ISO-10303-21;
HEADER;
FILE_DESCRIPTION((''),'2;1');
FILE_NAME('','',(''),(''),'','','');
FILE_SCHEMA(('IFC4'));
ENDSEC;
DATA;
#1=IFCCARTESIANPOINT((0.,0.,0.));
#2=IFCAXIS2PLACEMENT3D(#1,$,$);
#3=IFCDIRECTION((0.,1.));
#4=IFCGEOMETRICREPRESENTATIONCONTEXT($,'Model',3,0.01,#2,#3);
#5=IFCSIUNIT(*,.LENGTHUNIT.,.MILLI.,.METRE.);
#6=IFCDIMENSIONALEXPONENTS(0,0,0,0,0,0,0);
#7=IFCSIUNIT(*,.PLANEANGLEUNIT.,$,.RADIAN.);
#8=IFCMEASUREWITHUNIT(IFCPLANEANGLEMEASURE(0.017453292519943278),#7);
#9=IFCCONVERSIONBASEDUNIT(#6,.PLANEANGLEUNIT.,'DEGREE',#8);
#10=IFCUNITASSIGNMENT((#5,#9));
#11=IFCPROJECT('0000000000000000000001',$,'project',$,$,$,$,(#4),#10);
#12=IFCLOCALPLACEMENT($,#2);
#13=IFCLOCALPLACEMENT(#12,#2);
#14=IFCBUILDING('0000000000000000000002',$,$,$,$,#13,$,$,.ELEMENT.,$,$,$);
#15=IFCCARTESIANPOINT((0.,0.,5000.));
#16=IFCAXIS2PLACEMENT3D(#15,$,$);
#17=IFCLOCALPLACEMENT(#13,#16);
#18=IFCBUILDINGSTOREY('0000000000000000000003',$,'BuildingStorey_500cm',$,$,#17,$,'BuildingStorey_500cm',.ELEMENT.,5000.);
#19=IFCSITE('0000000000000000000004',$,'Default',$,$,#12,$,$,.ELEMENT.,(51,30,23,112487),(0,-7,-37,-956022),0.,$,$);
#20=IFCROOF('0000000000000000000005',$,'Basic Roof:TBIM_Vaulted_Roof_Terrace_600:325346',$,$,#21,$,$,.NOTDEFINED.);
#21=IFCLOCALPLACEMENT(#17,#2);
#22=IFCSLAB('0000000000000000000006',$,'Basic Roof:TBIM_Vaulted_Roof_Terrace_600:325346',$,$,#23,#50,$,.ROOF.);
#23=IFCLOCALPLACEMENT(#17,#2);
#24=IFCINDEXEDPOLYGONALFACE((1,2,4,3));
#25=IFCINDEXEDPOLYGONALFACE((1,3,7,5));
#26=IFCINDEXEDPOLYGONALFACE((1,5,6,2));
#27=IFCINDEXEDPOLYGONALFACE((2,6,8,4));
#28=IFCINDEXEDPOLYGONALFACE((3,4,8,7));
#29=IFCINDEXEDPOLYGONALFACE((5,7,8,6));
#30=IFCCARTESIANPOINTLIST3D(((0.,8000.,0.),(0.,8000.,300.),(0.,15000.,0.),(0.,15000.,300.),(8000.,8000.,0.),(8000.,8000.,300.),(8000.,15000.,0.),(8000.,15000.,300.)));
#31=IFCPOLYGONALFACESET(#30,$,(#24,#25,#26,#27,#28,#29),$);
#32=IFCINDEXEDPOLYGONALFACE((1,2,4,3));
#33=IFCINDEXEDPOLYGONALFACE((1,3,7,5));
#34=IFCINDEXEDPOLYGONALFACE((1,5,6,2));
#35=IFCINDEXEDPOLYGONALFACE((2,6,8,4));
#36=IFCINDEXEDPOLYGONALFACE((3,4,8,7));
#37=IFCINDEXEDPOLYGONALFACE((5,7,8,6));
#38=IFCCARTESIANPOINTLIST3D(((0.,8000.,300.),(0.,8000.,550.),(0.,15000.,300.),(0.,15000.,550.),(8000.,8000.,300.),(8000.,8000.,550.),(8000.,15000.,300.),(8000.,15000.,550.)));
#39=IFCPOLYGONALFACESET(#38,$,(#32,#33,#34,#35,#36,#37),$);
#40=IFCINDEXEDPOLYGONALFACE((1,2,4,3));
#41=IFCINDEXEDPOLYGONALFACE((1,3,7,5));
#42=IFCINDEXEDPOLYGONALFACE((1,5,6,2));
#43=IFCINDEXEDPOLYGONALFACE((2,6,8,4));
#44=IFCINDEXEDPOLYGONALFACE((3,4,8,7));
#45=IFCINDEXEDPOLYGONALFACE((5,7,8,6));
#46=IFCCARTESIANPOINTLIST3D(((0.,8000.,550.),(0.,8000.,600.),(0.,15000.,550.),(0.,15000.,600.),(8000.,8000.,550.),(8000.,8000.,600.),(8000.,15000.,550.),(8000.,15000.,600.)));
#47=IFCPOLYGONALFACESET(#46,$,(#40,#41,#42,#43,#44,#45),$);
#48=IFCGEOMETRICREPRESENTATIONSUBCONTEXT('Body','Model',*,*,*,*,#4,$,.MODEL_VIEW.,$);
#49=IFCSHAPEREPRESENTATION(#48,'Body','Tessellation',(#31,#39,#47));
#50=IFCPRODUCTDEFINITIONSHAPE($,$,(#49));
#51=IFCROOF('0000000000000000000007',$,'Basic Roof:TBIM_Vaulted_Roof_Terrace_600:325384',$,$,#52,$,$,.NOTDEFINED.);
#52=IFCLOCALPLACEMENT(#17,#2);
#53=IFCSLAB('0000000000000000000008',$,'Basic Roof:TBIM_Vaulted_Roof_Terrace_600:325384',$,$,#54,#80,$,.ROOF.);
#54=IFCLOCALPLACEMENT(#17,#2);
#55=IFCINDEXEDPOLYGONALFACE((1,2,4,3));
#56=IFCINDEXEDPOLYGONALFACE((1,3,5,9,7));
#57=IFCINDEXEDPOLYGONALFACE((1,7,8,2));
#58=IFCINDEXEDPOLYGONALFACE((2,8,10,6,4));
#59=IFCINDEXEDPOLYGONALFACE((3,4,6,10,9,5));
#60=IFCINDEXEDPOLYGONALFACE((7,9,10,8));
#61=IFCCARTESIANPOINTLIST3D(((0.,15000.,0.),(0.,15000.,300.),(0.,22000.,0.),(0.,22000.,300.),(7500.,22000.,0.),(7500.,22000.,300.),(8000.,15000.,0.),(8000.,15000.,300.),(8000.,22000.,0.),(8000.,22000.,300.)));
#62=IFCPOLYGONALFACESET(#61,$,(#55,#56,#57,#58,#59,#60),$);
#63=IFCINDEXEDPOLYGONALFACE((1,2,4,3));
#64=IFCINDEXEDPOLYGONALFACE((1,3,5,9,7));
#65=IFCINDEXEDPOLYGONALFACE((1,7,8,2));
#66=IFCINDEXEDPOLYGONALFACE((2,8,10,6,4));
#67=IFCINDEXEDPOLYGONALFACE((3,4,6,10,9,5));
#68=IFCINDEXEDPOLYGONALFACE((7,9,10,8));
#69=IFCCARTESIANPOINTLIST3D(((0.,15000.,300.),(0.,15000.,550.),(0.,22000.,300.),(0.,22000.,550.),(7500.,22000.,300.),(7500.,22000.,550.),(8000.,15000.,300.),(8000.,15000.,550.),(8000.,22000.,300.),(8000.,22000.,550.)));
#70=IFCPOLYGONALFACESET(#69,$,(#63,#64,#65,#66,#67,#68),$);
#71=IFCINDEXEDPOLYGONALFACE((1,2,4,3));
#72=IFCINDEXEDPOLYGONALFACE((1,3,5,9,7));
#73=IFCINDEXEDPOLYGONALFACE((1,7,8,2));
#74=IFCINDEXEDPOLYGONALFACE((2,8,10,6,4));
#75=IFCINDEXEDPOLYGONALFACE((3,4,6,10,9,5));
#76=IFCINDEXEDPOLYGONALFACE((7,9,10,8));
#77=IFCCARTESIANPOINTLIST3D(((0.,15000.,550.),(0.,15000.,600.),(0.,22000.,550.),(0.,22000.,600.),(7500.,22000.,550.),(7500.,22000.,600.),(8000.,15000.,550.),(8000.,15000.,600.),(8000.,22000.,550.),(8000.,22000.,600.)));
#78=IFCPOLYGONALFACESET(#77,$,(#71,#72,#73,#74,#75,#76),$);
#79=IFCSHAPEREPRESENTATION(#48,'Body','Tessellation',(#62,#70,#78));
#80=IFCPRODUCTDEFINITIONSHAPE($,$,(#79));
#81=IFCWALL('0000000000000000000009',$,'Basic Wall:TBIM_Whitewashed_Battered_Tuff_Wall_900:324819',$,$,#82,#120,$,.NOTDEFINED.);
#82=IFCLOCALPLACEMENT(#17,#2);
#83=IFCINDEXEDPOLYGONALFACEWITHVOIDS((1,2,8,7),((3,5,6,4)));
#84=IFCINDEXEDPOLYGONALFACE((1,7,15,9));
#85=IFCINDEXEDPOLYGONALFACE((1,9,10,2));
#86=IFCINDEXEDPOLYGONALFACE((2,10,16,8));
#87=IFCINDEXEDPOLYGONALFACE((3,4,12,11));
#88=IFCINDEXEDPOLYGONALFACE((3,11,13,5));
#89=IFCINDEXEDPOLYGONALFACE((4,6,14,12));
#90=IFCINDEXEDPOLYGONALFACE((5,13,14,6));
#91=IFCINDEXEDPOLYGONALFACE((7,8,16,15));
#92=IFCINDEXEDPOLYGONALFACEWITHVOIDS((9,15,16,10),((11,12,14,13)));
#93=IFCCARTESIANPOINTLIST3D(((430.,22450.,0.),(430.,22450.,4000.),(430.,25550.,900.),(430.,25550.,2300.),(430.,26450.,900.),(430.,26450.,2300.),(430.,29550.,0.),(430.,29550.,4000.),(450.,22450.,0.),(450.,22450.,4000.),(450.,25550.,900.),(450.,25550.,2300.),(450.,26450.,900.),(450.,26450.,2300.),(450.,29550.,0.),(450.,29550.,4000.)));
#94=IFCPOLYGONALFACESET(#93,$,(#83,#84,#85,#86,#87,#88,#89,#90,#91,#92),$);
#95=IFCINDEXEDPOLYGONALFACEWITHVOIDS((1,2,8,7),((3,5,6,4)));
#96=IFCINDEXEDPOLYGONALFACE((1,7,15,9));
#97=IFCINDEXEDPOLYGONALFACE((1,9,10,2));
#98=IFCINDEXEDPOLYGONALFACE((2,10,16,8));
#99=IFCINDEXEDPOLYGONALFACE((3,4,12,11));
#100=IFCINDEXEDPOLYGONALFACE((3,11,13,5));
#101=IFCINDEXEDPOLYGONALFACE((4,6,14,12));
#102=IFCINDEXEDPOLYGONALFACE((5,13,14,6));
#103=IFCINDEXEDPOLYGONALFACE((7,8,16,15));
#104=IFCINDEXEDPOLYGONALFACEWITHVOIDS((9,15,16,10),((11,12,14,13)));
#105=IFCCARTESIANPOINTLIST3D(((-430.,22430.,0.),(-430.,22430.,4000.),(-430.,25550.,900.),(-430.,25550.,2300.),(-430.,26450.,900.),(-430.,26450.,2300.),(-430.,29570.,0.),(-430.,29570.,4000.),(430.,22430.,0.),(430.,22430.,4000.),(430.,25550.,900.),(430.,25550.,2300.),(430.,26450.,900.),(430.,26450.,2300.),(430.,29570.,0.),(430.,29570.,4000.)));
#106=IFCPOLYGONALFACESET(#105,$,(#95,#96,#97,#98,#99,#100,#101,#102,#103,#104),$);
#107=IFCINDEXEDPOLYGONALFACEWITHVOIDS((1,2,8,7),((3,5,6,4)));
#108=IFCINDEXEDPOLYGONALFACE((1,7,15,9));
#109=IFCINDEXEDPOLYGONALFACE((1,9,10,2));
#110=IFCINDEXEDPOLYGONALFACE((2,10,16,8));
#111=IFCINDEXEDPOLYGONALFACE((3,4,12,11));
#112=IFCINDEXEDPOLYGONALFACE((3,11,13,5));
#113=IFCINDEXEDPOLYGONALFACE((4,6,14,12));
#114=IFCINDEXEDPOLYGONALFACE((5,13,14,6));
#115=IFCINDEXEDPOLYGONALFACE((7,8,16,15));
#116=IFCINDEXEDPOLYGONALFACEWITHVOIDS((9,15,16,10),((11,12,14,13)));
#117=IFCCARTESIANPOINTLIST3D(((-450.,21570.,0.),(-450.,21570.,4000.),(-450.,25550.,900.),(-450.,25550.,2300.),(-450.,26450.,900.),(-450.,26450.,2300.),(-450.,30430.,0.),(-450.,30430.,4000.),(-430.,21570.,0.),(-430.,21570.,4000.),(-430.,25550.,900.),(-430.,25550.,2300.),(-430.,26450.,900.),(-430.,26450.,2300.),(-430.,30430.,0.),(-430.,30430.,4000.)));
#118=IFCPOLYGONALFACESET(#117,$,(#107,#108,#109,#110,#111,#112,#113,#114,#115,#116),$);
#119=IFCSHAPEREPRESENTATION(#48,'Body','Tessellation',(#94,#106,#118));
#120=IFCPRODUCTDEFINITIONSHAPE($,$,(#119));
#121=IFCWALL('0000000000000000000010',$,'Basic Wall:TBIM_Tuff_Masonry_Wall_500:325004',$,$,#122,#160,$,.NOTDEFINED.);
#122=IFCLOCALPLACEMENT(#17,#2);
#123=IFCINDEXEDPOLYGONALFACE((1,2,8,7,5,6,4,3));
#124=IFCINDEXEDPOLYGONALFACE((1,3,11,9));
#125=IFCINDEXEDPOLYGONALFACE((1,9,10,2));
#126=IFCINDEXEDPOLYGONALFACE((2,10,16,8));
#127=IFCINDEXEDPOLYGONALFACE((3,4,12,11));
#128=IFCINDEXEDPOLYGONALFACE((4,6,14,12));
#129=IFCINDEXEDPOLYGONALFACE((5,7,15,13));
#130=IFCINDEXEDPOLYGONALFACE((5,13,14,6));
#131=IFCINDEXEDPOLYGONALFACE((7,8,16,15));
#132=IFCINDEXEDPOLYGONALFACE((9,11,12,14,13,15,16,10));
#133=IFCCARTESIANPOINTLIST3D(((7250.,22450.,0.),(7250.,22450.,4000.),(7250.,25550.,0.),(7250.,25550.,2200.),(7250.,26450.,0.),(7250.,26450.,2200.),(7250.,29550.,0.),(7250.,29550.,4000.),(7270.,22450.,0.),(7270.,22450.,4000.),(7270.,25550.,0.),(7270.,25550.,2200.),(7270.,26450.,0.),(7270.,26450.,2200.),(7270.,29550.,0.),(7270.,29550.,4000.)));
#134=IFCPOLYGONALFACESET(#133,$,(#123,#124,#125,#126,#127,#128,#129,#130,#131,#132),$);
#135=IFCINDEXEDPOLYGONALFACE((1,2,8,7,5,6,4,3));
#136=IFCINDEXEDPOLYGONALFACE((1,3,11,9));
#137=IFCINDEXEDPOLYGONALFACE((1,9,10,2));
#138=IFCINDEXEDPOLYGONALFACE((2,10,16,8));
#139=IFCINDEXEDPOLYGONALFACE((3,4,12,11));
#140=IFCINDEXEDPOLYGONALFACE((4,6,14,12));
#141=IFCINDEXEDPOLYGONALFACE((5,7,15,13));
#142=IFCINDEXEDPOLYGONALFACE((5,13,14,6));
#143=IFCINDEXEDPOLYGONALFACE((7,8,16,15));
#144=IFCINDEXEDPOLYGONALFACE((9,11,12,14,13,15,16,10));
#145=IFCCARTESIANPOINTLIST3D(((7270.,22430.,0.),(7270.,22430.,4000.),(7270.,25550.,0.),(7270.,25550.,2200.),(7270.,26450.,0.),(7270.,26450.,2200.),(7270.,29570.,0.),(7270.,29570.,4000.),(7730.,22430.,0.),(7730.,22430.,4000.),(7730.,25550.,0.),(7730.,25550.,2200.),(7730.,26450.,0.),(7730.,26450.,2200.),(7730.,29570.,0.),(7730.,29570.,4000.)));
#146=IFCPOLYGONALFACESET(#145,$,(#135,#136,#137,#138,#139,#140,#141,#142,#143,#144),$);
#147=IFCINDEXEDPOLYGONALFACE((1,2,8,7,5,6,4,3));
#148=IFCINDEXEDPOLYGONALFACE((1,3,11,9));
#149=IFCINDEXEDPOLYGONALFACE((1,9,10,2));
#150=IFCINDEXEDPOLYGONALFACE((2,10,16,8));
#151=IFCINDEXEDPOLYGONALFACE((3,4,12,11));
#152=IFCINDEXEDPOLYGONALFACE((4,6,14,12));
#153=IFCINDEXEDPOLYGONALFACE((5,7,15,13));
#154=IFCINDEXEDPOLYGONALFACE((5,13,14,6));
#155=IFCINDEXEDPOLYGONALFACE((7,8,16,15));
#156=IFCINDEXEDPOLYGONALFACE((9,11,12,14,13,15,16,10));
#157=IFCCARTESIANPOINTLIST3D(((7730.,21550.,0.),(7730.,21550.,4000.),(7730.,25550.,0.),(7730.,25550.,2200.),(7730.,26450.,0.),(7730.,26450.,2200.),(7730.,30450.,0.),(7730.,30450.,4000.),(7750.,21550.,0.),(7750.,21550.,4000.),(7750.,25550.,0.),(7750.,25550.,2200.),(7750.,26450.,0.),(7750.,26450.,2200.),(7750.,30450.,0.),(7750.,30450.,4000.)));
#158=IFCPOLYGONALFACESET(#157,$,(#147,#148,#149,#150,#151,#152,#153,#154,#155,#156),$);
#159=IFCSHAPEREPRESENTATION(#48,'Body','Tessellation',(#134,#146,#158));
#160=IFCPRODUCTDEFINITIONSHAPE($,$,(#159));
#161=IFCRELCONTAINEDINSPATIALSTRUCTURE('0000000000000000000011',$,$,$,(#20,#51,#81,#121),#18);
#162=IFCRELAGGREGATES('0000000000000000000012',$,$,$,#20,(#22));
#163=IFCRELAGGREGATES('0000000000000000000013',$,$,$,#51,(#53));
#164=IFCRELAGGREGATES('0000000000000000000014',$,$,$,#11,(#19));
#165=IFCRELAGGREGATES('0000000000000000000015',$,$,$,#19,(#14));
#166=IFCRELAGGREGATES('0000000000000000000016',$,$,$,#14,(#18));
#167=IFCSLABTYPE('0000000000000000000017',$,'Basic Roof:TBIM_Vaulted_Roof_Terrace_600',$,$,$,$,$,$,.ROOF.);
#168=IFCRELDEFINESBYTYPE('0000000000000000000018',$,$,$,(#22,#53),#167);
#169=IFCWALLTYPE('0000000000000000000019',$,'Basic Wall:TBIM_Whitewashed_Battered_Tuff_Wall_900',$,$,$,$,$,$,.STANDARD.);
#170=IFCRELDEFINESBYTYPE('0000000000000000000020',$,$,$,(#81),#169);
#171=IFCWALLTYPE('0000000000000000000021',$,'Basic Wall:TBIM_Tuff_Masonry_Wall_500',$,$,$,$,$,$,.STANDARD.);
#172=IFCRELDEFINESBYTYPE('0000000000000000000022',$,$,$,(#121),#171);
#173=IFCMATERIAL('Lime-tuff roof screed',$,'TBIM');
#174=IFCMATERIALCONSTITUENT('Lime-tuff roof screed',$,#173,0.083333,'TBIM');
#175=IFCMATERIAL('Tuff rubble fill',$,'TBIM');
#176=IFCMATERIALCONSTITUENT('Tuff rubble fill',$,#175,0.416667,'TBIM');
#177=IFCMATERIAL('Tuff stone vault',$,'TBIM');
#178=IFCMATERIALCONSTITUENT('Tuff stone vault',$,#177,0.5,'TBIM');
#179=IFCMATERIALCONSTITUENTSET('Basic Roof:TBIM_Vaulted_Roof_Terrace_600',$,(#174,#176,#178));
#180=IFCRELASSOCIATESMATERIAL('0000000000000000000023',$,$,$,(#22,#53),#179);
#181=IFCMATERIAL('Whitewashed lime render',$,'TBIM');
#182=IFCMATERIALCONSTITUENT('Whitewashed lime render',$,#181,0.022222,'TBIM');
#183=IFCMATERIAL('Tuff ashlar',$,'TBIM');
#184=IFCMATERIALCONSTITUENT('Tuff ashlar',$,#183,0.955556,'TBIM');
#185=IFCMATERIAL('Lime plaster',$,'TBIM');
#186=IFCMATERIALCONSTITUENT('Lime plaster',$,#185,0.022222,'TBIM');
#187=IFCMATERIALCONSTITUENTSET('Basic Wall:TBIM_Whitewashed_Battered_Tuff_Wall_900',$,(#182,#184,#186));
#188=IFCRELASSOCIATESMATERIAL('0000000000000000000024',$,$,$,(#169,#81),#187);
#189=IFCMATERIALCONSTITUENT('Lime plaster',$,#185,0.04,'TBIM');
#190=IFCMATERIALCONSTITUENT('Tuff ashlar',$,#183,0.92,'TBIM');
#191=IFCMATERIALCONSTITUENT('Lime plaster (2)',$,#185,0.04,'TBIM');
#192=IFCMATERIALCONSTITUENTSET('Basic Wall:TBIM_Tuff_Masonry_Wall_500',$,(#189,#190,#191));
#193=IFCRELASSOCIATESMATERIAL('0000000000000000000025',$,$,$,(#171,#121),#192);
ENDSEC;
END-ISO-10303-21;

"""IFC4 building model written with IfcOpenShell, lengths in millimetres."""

from ifc_helpers import new_model, entity, si_unit, converted_unit, direction, frame, origin, place, context, subcontext, project, spatial, indexed_curve, outline, extrude, material, constituent, constituent_set, type_object, element, aggregate, save


model = new_model("IFC4")

# Units and contexts
model_context = context("Model", 3, precision=0.01, world=origin(), true_north=direction((0.0, 1.0)))
body_context = subcontext(model_context, "Body", "Model", "MODEL_VIEW")
ifc_project = project(units=[si_unit("LENGTHUNIT", "METRE", prefix="MILLI"), converted_unit("PLANEANGLEUNIT", "DEGREE", entity("IfcPlaneAngleMeasure", 0.017453292519943278), si_unit("PLANEANGLEUNIT", "RADIAN"), dimensions=[0, 0, 0, 0, 0, 0, 0])], contexts=[model_context])

# Site, building, storey
site_placement = place(None, origin())
site = spatial("IfcSite", under=ifc_project, at=site_placement, Name="Default", CompositionType="ELEMENT", RefLatitude=(51, 30, 23, 112487), RefLongitude=(0, -7, -37, -956022), RefElevation=0.0)
building_placement = place(site_placement, origin())
building = spatial("IfcBuilding", under=site, at=building_placement, CompositionType="ELEMENT")
storey_placement = place(building_placement, frame((0.0, 0.0, 5000.0)))
storey = spatial("IfcBuildingStorey", under=building, at=storey_placement, Name="BuildingStorey_500cm", LongName="BuildingStorey_500cm", CompositionType="ELEMENT", Elevation=5000.0)

# Shared definitions
ifc_material_1 = material(Name="Tuff rubble fill", Category="TBIM")
ifc_material_2 = material(Name="Tuff stone vault", Category="TBIM")

# Roofs, slabs
ifc_material_3 = material(Name="Lime-tuff roof screed", Category="TBIM")
ifc_constituent_1 = constituent(ifc_material_3, Name="Lime-tuff roof screed", Category="TBIM", fraction=0.083333)
ifc_constituent_2 = constituent(ifc_material_1, Name="Tuff rubble fill", Category="TBIM", fraction=0.416667)
ifc_constituent_3 = constituent(ifc_material_2, Name="Tuff stone vault", Category="TBIM", fraction=0.5)
ifc_constituent_set_1 = constituent_set(constituents=[ifc_constituent_1, ifc_constituent_2, ifc_constituent_3], Name="Basic Roof:TBIM_Vaulted_Roof_Terrace_600")
slab_type_1 = type_object("IfcSlabType", Name="Basic Roof:TBIM_Vaulted_Roof_Terrace_600", PredefinedType="ROOF")
roof_1_placement = place(storey_placement, frame((0.0, 8000.0, 0.0)))
roof_1 = element("IfcRoof", 1, at=roof_1_placement, inside=storey, Name="Basic Roof:TBIM_Vaulted_Roof_Terrace_600:325346", PredefinedType="NOTDEFINED")
slab_1_placement = place(roof_1_placement, origin())
slab_1 = element("IfcSlab", 2, at=slab_1_placement, type_object=slab_type_1, material=ifc_constituent_set_1, Name="Basic Roof:TBIM_Vaulted_Roof_Terrace_600:325346", PredefinedType="ROOF", context=body_context, shape_type="SweptSolid", body=[
    extrude(outline(indexed_curve([(-4000.0, 3500.0), (-4000.0, -3500.0), (4000.0, -3500.0), (4000.0, 3500.0), (-4000.0, 3500.0)], self_intersect=False)), frame((4000.0, 3500.0, 0.0)), (0.0, 0.0, 1.0), 300.0),
    extrude(outline(indexed_curve([(-4000.0, 3500.0), (-4000.0, -3500.0), (4000.0, -3500.0), (4000.0, 3500.0), (-4000.0, 3500.0)], self_intersect=False)), frame((4000.0, 3500.0, 300.0)), (0.0, 0.0, 1.0), 250.0),
    extrude(outline(indexed_curve([(-4000.0, 3500.0), (-4000.0, -3500.0), (4000.0, -3500.0), (4000.0, 3500.0), (-4000.0, 3500.0)], self_intersect=False)), frame((4000.0, 3500.0, 550.0)), (0.0, 0.0, 1.0), 50.0),
])
aggregate(roof_1, [slab_1])
roof_2_placement = place(storey_placement, frame((0.0, 15000.0, 0.0)))
roof_2 = element("IfcRoof", 3, at=roof_2_placement, inside=storey, Name="Basic Roof:TBIM_Vaulted_Roof_Terrace_600:325384", PredefinedType="NOTDEFINED")
slab_2_placement = place(roof_2_placement, origin())
slab_2 = element("IfcSlab", 4, at=slab_2_placement, type_object=slab_type_1, material=ifc_constituent_set_1, Name="Basic Roof:TBIM_Vaulted_Roof_Terrace_600:325384", PredefinedType="ROOF", context=body_context, shape_type="SweptSolid", body=[
    extrude(outline(indexed_curve([(4000.0, 3500.0), (3500.0, 3500.0), (-4000.0, 3500.0), (-4000.0, -3500.0), (4000.0, -3500.0), (4000.0, 3500.0)], self_intersect=False)), frame((4000.0, 3500.0, 0.0)), (0.0, 0.0, 1.0), 300.0),
    extrude(outline(indexed_curve([(4000.0, 3500.0), (3500.0, 3500.0), (-4000.0, 3500.0), (-4000.0, -3500.0), (4000.0, -3500.0), (4000.0, 3500.0)], self_intersect=False)), frame((4000.0, 3500.0, 300.0)), (0.0, 0.0, 1.0), 250.0),
    extrude(outline(indexed_curve([(4000.0, 3500.0), (3500.0, 3500.0), (-4000.0, 3500.0), (-4000.0, -3500.0), (4000.0, -3500.0), (4000.0, 3500.0)], self_intersect=False)), frame((4000.0, 3500.0, 550.0)), (0.0, 0.0, 1.0), 50.0),
])
aggregate(roof_2, [slab_2])

# Walls, openings
ifc_material_4 = material(Name="Whitewashed lime render", Category="TBIM")
ifc_constituent_4 = constituent(ifc_material_4, Name="Whitewashed lime render", Category="TBIM", fraction=0.022222)
ifc_material_5 = material(Name="Tuff ashlar", Category="TBIM")
ifc_constituent_5 = constituent(ifc_material_5, Name="Tuff ashlar", Category="TBIM", fraction=0.955556)
ifc_material_6 = material(Name="Lime plaster", Category="TBIM")
ifc_constituent_6 = constituent(ifc_material_6, Name="Lime plaster", Category="TBIM", fraction=0.022222)
ifc_constituent_set_2 = constituent_set(constituents=[ifc_constituent_4, ifc_constituent_5, ifc_constituent_6], Name="Basic Wall:TBIM_Whitewashed_Battered_Tuff_Wall_900")
wall_type_1 = type_object("IfcWallType", Name="Basic Wall:TBIM_Whitewashed_Battered_Tuff_Wall_900", PredefinedType="STANDARD", material=ifc_constituent_set_2)
wall_1_placement = place(storey_placement, frame((0.0, 22450.0, 0.0), z_axis=(0.0, 0.0, 1.0), x_axis=(0.0, 1.0, 0.0)))
wall_1 = element("IfcWall", 5, at=wall_1_placement, inside=storey, type_object=wall_type_1, material=ifc_constituent_set_2, Name="Basic Wall:TBIM_Whitewashed_Battered_Tuff_Wall_900:324819", PredefinedType="NOTDEFINED", context=body_context, shape_type="SweptSolid", body=[
    extrude(outline(indexed_curve([(-2000.0, -3550.0), (2000.0, -3550.0), (2000.0, 3550.0), (-2000.0, 3550.0), (-2000.0, -3550.0)], self_intersect=False), holes=[indexed_curve([(300.0, 450.0), (300.0, -450.0), (-1100.0, -450.0), (-1100.0, 450.0), (300.0, 450.0)], self_intersect=False)]), frame((3550.0, -430.0, 2000.0), z_axis=(0.0, -1.0, 0.0), x_axis=(0.0, 0.0, 1.0)), (0.0, 0.0, 1.0), 20.0),
    extrude(outline(indexed_curve([(-2000.0, -3570.0), (2000.0, -3570.0), (2000.0, 3570.0), (-2000.0, 3570.0), (-2000.0, -3570.0)], self_intersect=False), holes=[indexed_curve([(300.0, 450.0), (300.0, -450.0), (-1100.0, -450.0), (-1100.0, 450.0), (300.0, 450.0)], self_intersect=False)]), frame((3550.0, 430.0, 2000.0), z_axis=(0.0, -1.0, 0.0), x_axis=(0.0, 0.0, 1.0)), (0.0, 0.0, 1.0), 860.0),
    extrude(outline(indexed_curve([(-4430.0, -2000.0), (4430.0, -2000.0), (4430.0, 2000.0), (-4430.0, 2000.0), (-4430.0, -2000.0)], self_intersect=False), holes=[indexed_curve([(-450.0, 300.0), (450.0, 300.0), (450.0, -1100.0), (-450.0, -1100.0), (-450.0, 300.0)], self_intersect=False)]), frame((3550.0, 450.0, 2000.0), z_axis=(0.0, -1.0, 0.0), x_axis=(1.0, 0.0, 0.0)), (0.0, 0.0, 1.0), 20.0),
])
opening_1_placement = place(wall_1_placement, frame((3100.0, -450.0, 900.0)))
element("IfcOpeningElement", 6, at=opening_1_placement, cuts=wall_1, PredefinedType="OPENING", context=body_context, shape_type="SweptSolid", body=[
    extrude(outline(indexed_curve([(1400.0, 0.0), (1400.0, 900.0), (0.0, 900.0), (0.0, 0.0), (1400.0, 0.0)], self_intersect=False)), frame((0.0, 0.0, 0.0), z_axis=(0.0, 1.0, 0.0), x_axis=(0.0, 0.0, 1.0)), (0.0, 0.0, 1.0), 900.0),
])
ifc_constituent_7 = constituent(ifc_material_6, Name="Lime plaster", Category="TBIM", fraction=0.04)
ifc_constituent_8 = constituent(ifc_material_5, Name="Tuff ashlar", Category="TBIM", fraction=0.92)
ifc_constituent_9 = constituent(ifc_material_6, Name="Lime plaster (2)", Category="TBIM", fraction=0.04)
ifc_constituent_set_3 = constituent_set(constituents=[ifc_constituent_7, ifc_constituent_8, ifc_constituent_9], Name="Basic Wall:TBIM_Tuff_Masonry_Wall_500")
wall_type_2 = type_object("IfcWallType", Name="Basic Wall:TBIM_Tuff_Masonry_Wall_500", PredefinedType="STANDARD", material=ifc_constituent_set_3)
wall_2_placement = place(storey_placement, frame((7500.0, 22450.0, 0.0), z_axis=(0.0, 0.0, 1.0), x_axis=(0.0, 1.0, 0.0)))
wall_2 = element("IfcWall", 7, at=wall_2_placement, inside=storey, type_object=wall_type_2, material=ifc_constituent_set_3, Name="Basic Wall:TBIM_Tuff_Masonry_Wall_500:325004", PredefinedType="NOTDEFINED", context=body_context, shape_type="SweptSolid", body=[
    extrude(outline(indexed_curve([(-2450.0, -3550.0), (1550.0, -3550.0), (1550.0, -450.0), (-650.0, -450.0), (-650.0, 450.0), (1550.0, 450.0), (1550.0, 3550.0), (-2450.0, 3550.0), (-2450.0, -3550.0)], self_intersect=False)), frame((3550.0, 250.0, 1550.0), z_axis=(0.0, -1.0, 0.0), x_axis=(0.0, 0.0, -1.0)), (0.0, 0.0, 1.0), 20.0),
    extrude(outline(indexed_curve([(-1550.0, -450.0), (-1550.0, -3570.0), (2450.0, -3570.0), (2450.0, 3570.0), (-1550.0, 3570.0), (-1550.0, 450.0), (650.0, 450.0), (650.0, -450.0), (-1550.0, -450.0)], self_intersect=False)), frame((3550.0, 230.0, 1550.0), z_axis=(0.0, 1.0, 0.0), x_axis=(0.0, 0.0, 1.0)), (0.0, 0.0, -1.0), 460.0),
    extrude(outline(indexed_curve([(-1550.0, -450.0), (-1550.0, -4450.0), (2450.0, -4450.0), (2450.0, 4450.0), (-1550.0, 4450.0), (-1550.0, 450.0), (650.0, 450.0), (650.0, -450.0), (-1550.0, -450.0)], self_intersect=False)), frame((3550.0, -230.0, 1550.0), z_axis=(0.0, 1.0, 0.0), x_axis=(0.0, 0.0, 1.0)), (0.0, 0.0, -1.0), 20.0),
])
opening_2_placement = place(wall_2_placement, frame((3100.0, -250.0, 0.0)))
element("IfcOpeningElement", 8, at=opening_2_placement, cuts=wall_2, PredefinedType="OPENING", context=body_context, shape_type="SweptSolid", body=[
    extrude(outline(indexed_curve([(0.0, 900.0), (0.0, 0.0), (2200.0, 0.0), (2200.0, 900.0), (0.0, 900.0)], self_intersect=False)), frame((0.0, 0.0, 0.0), z_axis=(0.0, 1.0, 0.0), x_axis=(0.0, 0.0, 1.0)), (0.0, 0.0, 1.0), 500.0),
])

save(model, "model.ifc")
